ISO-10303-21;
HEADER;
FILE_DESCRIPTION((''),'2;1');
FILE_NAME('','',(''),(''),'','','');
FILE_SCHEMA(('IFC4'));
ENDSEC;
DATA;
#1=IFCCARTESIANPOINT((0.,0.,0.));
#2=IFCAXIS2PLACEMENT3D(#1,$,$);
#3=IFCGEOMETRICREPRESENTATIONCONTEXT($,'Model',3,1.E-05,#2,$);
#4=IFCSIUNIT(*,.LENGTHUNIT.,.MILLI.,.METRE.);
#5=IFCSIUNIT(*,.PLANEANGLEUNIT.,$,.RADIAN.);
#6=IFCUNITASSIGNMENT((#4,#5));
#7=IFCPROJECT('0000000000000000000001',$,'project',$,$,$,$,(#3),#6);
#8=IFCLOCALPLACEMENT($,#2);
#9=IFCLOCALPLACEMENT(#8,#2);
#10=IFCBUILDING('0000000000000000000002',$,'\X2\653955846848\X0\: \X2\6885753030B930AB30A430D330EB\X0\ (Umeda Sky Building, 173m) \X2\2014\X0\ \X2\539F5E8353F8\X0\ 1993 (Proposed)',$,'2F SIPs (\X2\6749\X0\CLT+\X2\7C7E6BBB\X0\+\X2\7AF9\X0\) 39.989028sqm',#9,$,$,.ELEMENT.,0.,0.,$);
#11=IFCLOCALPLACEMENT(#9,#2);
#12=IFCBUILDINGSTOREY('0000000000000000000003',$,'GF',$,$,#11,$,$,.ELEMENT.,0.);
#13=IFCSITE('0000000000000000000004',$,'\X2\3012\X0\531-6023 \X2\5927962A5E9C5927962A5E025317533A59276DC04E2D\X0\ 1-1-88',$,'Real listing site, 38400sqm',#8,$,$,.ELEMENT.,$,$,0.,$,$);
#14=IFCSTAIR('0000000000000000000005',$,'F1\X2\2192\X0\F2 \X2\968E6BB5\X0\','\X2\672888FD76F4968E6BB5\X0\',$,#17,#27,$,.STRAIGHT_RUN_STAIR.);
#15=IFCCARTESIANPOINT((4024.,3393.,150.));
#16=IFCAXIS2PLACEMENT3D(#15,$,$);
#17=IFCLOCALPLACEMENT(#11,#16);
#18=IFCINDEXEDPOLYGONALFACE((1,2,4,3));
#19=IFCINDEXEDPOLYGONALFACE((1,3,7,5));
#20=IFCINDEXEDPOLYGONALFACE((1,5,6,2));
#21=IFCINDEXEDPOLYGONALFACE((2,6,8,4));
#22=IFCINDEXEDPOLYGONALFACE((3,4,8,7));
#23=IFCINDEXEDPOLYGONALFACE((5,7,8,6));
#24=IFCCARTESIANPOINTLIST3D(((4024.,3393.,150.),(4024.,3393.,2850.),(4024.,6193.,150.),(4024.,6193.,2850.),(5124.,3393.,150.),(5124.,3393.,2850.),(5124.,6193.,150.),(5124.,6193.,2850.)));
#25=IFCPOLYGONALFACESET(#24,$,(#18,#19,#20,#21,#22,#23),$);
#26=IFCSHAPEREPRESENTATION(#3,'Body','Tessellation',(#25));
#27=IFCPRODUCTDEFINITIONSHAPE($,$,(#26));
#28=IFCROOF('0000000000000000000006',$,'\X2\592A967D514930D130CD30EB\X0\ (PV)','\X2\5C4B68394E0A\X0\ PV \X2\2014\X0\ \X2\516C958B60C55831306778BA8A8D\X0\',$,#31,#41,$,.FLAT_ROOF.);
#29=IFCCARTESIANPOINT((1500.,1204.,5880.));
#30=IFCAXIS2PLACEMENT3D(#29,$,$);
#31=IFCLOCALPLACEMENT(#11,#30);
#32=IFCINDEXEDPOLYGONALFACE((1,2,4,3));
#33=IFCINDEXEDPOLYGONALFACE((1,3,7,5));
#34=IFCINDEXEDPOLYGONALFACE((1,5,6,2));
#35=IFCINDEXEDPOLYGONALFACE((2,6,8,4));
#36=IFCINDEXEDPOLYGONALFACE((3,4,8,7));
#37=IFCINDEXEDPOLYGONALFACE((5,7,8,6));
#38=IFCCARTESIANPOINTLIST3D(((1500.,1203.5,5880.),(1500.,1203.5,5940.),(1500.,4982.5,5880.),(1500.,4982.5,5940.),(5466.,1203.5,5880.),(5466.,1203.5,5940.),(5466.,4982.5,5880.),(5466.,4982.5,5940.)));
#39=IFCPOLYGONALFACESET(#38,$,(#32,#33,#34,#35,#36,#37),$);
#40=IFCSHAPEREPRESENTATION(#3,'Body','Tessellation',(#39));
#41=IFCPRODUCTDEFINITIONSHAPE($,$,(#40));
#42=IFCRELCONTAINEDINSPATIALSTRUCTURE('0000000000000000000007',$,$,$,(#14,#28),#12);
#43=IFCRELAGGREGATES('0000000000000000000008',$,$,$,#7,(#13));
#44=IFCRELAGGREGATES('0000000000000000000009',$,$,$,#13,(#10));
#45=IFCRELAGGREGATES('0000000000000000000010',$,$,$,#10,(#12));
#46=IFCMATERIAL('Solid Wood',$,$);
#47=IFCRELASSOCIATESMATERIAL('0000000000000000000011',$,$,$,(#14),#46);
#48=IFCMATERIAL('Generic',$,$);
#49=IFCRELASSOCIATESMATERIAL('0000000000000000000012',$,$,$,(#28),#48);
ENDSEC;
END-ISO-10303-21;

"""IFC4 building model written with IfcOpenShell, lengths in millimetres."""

from ifc_helpers import new_model, si_unit, frame, frame_2d, origin, place, context, project, spatial, rectangle, extrude, material, element, save


model = new_model("IFC4")

# Units and contexts
model_context = context("Model", 3, precision=1e-05, world=origin())
ifc_project = project(units=[si_unit("LENGTHUNIT", "METRE", prefix="MILLI"), si_unit("PLANEANGLEUNIT", "RADIAN")], contexts=[model_context])

# Site, building, storey
site_placement = place(None, origin())
site = spatial("IfcSite", under=ifc_project, at=site_placement, Name="〒531-6023 大阪府大阪市北区大淀中 1-1-88", ObjectType="Real listing site, 38400sqm", CompositionType="ELEMENT", RefElevation=0.0)
building_placement = place(site_placement, origin())
building = spatial("IfcBuilding", under=site, at=building_placement, Name="改善案: 梅田スカイビル (Umeda Sky Building, 173m) — 原広司 1993 (Proposed)", ObjectType="2F SIPs (杉CLT+籾殻+竹) 39.989028sqm", CompositionType="ELEMENT", ElevationOfRefHeight=0.0, ElevationOfTerrain=0.0)
storey_placement = place(building_placement, origin())
storey = spatial("IfcBuildingStorey", under=building, at=storey_placement, Name="GF", CompositionType="ELEMENT", Elevation=0.0)

# Shared definitions
ifc_material_1 = material(Name="Generic")

# Stair
ifc_material_2 = material(Name="Solid Wood")
stair_placement = place(storey_placement, frame((4024.0, 3393.0, 150.0)))
element("IfcStair", 1, at=stair_placement, inside=storey, material=ifc_material_2, Name="F1→F2 階段", Description="木製直階段", PredefinedType="STRAIGHT_RUN_STAIR", context=model_context, shape_type="SweptSolid", body=[
    extrude(rectangle(XDim=1100.0, YDim=2800.0, at=frame_2d((550.0, 1400.0))), frame((4024.0, 3393.0, 150.0)), (0.0, 0.0, 1.0), 2700.0),
])

# Roof
roof_placement = place(storey_placement, frame((1500.0, 1204.0, 5880.0)))
element("IfcRoof", 2, at=roof_placement, inside=storey, material=ifc_material_1, Name="太陽光パネル (PV)", Description="屋根上 PV — 公開情報で確認", PredefinedType="FLAT_ROOF", context=model_context, shape_type="SweptSolid", body=[
    extrude(rectangle(XDim=3966.0, YDim=3779.0, at=frame_2d((1983.0, 1889.0))), frame((1500.0, 1204.0, 5880.0)), (0.0, 0.0, 1.0), 60.0),
])

save(model, "model.ifc")
